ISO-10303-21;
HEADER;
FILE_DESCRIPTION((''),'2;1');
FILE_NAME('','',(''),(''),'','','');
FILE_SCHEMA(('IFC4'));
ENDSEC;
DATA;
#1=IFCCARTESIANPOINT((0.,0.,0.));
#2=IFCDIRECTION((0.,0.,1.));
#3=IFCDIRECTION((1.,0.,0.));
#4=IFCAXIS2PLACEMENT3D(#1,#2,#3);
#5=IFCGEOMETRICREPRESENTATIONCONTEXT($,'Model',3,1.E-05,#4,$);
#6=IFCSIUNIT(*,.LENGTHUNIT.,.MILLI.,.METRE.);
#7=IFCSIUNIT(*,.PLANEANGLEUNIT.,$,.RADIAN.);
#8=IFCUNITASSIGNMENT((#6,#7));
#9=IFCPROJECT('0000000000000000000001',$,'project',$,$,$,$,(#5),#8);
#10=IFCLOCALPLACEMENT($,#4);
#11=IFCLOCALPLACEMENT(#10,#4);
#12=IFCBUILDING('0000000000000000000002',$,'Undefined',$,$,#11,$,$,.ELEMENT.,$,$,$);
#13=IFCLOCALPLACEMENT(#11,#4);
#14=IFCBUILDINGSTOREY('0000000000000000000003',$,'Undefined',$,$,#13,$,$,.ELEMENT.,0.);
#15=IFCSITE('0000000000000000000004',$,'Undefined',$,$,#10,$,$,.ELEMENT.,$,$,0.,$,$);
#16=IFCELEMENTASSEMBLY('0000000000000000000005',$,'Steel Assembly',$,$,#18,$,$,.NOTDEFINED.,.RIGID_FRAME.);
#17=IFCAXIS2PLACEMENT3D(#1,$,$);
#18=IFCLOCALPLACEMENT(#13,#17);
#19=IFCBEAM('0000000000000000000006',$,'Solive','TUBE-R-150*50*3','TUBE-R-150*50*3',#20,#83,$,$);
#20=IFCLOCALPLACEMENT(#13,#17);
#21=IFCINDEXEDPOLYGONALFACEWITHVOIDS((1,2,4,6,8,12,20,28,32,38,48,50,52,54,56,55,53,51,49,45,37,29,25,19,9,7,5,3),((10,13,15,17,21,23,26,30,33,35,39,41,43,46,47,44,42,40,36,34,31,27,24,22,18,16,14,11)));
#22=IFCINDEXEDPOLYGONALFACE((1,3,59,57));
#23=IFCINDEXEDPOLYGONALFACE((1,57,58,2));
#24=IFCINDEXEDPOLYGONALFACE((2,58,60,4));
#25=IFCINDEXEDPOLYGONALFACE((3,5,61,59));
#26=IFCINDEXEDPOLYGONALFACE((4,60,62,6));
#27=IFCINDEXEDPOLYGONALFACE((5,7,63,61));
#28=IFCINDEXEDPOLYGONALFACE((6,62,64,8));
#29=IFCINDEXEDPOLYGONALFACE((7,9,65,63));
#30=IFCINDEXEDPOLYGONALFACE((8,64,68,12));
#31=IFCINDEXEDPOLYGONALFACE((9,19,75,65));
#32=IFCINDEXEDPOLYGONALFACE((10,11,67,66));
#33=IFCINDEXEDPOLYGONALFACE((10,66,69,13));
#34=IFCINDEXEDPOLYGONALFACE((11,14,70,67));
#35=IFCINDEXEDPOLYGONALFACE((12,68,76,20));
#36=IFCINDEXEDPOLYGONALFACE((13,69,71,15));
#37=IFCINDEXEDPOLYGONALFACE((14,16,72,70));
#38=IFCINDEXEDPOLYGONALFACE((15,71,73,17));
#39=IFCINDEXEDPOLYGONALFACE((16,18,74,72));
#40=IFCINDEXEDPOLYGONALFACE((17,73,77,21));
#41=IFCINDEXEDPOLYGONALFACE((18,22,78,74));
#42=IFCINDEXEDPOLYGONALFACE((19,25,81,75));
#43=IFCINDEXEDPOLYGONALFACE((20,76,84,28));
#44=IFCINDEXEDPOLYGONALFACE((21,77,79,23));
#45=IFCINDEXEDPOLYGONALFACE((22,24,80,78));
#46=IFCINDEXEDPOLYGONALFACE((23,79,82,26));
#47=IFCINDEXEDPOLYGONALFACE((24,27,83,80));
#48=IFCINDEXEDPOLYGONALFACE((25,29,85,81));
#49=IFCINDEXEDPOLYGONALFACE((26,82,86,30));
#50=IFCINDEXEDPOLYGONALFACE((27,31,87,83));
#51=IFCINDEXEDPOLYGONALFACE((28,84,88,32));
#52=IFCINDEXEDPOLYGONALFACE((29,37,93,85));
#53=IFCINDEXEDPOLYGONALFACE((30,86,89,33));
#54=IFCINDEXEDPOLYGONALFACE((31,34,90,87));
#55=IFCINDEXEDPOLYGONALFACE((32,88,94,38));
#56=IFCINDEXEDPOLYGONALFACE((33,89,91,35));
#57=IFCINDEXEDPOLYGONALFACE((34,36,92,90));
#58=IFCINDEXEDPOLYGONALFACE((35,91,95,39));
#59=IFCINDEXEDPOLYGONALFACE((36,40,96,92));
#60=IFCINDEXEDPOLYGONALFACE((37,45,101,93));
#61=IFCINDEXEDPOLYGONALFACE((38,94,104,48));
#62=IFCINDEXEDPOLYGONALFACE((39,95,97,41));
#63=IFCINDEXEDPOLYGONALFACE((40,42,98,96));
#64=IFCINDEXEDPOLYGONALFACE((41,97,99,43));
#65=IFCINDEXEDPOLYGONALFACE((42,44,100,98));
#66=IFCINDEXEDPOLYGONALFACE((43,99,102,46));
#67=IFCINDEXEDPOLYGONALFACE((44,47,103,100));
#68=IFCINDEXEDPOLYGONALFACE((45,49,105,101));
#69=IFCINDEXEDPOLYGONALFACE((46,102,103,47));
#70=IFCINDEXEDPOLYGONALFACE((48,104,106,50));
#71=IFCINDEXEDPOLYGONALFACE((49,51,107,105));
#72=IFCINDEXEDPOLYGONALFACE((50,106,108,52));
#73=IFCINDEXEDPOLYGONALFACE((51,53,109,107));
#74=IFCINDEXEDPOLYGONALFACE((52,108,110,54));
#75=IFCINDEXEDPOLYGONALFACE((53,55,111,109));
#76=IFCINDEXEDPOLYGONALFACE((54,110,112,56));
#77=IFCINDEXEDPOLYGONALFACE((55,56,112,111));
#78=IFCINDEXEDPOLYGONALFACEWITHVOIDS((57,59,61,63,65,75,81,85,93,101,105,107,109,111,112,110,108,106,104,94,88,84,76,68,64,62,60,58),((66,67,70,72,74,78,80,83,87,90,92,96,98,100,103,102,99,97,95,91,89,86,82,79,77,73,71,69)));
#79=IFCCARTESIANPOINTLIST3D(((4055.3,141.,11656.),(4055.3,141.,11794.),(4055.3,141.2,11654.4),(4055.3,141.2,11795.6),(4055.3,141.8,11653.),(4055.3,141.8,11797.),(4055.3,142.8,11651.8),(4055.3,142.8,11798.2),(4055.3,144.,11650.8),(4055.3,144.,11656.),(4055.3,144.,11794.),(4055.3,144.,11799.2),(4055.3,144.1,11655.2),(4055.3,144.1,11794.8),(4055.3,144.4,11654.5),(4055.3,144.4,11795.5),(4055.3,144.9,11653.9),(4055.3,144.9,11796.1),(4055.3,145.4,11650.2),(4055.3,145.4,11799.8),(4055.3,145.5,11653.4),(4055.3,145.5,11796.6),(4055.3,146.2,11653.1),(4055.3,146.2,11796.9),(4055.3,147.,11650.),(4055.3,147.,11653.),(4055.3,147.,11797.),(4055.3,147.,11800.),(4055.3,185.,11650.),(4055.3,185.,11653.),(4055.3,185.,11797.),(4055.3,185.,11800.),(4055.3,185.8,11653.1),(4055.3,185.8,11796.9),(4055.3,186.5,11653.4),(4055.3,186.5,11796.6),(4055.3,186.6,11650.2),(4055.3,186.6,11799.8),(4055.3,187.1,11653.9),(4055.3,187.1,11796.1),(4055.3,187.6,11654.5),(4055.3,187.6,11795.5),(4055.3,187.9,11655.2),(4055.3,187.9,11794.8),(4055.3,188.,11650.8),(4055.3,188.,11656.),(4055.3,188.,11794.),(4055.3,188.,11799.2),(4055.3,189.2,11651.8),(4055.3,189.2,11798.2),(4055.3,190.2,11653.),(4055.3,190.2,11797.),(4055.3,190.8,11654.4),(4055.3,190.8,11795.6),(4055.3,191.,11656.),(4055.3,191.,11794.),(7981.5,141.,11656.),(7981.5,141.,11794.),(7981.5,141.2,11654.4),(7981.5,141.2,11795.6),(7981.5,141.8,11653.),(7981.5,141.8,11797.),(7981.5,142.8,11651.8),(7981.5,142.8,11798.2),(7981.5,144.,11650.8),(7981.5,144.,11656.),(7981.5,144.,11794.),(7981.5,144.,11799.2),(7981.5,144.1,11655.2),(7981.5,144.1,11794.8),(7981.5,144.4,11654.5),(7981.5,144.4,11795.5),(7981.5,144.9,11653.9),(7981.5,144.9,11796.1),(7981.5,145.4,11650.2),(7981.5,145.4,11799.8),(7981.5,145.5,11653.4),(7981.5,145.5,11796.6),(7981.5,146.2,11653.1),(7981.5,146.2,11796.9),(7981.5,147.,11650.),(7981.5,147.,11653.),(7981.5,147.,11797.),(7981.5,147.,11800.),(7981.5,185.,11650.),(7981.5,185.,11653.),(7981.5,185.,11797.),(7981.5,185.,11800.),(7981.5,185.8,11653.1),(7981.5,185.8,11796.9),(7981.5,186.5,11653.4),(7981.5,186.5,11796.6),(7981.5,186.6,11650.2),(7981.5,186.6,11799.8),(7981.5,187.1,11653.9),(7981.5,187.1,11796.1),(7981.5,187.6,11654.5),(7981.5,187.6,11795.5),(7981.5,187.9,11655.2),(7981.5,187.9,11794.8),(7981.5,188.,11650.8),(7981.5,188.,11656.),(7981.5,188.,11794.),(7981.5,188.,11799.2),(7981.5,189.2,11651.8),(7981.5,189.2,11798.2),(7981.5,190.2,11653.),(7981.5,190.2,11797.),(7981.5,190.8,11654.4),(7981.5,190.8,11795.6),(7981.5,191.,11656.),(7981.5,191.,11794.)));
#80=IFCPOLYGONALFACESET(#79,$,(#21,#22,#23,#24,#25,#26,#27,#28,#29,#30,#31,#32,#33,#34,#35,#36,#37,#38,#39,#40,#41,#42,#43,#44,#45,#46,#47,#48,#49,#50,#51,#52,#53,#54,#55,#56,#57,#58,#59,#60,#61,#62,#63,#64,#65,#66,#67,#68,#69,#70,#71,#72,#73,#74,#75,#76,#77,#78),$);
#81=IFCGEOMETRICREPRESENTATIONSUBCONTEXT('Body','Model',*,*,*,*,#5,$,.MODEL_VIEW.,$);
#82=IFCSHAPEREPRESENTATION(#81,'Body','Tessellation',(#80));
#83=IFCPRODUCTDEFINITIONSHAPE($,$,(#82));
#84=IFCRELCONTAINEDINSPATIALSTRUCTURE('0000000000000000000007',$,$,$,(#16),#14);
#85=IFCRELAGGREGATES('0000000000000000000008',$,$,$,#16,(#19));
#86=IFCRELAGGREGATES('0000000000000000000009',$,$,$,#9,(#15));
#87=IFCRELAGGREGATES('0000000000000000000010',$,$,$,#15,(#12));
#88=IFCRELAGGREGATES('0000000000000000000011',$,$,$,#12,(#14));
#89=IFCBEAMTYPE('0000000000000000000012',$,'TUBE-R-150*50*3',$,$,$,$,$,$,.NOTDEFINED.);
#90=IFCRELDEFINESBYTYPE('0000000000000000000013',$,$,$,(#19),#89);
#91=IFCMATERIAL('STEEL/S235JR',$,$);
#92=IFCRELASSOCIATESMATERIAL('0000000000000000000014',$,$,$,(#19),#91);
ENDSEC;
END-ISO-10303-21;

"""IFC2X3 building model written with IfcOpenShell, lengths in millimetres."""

from ifc_helpers import new_model, si_unit, frame, origin_with_axes, origin_2d_with_axis, place, context, subcontext, project, spatial, hollow_rectangle, extrude, material, type_object, element, aggregate, save


model = new_model("IFC2X3")

# Units and contexts
model_context = context("Model", 3, precision=1e-05, world=origin_with_axes())
body_context = subcontext(model_context, "Body", "Model", "MODEL_VIEW")
ifc_project = project(units=[si_unit("LENGTHUNIT", "METRE", prefix="MILLI"), si_unit("PLANEANGLEUNIT", "RADIAN")], contexts=[model_context])

# Site, building, storey
site_placement = place(None, origin_with_axes())
site = spatial("IfcSite", under=ifc_project, at=site_placement, Name="Undefined", CompositionType="ELEMENT", RefElevation=0.0)
building_placement = place(site_placement, origin_with_axes())
building = spatial("IfcBuilding", under=site, at=building_placement, Name="Undefined", CompositionType="ELEMENT")
storey_placement = place(building_placement, origin_with_axes())
storey = spatial("IfcBuildingStorey", under=building, at=storey_placement, Name="Undefined", CompositionType="ELEMENT", Elevation=0.0)

# Element assembly, beam
ifc_material_1 = material(Name="STEEL/S235JR")
beam_type_1 = type_object("IfcBeamType", Name="TUBE-R-150*50*3", PredefinedType="NOTDEFINED")
assembly_1_placement = place(storey_placement, origin_with_axes())
assembly_1 = element("IfcElementAssembly", 1, at=assembly_1_placement, inside=storey, Name="Steel Assembly", AssemblyPlace="NOTDEFINED", PredefinedType="RIGID_FRAME")
beam_1_placement = place(assembly_1_placement, frame((4055.3, 166.0, 11725.0), z_axis=(0.0, 0.0, 1.0), x_axis=(1.0, 0.0, 0.0)))
beam_1 = element("IfcBeam", 2, at=beam_1_placement, type_object=beam_type_1, material=ifc_material_1, Name="Solive", Description="TUBE-R-150*50*3", ObjectType="TUBE-R-150*50*3", context=body_context, shape_type="SweptSolid", body=[
    extrude(hollow_rectangle(XDim=50.0, YDim=150.0, WallThickness=3.0, InnerFilletRadius=3.0, OuterFilletRadius=6.0, at=origin_2d_with_axis()), frame((3926.2, 0.0, 0.0), z_axis=(-1.0, 0.0, 0.0), x_axis=(0.0, -1.0, 0.0)), (0.0, 0.0, 1.0), 3926.2),
])
aggregate(assembly_1, [beam_1])

save(model, "model.ifc")
